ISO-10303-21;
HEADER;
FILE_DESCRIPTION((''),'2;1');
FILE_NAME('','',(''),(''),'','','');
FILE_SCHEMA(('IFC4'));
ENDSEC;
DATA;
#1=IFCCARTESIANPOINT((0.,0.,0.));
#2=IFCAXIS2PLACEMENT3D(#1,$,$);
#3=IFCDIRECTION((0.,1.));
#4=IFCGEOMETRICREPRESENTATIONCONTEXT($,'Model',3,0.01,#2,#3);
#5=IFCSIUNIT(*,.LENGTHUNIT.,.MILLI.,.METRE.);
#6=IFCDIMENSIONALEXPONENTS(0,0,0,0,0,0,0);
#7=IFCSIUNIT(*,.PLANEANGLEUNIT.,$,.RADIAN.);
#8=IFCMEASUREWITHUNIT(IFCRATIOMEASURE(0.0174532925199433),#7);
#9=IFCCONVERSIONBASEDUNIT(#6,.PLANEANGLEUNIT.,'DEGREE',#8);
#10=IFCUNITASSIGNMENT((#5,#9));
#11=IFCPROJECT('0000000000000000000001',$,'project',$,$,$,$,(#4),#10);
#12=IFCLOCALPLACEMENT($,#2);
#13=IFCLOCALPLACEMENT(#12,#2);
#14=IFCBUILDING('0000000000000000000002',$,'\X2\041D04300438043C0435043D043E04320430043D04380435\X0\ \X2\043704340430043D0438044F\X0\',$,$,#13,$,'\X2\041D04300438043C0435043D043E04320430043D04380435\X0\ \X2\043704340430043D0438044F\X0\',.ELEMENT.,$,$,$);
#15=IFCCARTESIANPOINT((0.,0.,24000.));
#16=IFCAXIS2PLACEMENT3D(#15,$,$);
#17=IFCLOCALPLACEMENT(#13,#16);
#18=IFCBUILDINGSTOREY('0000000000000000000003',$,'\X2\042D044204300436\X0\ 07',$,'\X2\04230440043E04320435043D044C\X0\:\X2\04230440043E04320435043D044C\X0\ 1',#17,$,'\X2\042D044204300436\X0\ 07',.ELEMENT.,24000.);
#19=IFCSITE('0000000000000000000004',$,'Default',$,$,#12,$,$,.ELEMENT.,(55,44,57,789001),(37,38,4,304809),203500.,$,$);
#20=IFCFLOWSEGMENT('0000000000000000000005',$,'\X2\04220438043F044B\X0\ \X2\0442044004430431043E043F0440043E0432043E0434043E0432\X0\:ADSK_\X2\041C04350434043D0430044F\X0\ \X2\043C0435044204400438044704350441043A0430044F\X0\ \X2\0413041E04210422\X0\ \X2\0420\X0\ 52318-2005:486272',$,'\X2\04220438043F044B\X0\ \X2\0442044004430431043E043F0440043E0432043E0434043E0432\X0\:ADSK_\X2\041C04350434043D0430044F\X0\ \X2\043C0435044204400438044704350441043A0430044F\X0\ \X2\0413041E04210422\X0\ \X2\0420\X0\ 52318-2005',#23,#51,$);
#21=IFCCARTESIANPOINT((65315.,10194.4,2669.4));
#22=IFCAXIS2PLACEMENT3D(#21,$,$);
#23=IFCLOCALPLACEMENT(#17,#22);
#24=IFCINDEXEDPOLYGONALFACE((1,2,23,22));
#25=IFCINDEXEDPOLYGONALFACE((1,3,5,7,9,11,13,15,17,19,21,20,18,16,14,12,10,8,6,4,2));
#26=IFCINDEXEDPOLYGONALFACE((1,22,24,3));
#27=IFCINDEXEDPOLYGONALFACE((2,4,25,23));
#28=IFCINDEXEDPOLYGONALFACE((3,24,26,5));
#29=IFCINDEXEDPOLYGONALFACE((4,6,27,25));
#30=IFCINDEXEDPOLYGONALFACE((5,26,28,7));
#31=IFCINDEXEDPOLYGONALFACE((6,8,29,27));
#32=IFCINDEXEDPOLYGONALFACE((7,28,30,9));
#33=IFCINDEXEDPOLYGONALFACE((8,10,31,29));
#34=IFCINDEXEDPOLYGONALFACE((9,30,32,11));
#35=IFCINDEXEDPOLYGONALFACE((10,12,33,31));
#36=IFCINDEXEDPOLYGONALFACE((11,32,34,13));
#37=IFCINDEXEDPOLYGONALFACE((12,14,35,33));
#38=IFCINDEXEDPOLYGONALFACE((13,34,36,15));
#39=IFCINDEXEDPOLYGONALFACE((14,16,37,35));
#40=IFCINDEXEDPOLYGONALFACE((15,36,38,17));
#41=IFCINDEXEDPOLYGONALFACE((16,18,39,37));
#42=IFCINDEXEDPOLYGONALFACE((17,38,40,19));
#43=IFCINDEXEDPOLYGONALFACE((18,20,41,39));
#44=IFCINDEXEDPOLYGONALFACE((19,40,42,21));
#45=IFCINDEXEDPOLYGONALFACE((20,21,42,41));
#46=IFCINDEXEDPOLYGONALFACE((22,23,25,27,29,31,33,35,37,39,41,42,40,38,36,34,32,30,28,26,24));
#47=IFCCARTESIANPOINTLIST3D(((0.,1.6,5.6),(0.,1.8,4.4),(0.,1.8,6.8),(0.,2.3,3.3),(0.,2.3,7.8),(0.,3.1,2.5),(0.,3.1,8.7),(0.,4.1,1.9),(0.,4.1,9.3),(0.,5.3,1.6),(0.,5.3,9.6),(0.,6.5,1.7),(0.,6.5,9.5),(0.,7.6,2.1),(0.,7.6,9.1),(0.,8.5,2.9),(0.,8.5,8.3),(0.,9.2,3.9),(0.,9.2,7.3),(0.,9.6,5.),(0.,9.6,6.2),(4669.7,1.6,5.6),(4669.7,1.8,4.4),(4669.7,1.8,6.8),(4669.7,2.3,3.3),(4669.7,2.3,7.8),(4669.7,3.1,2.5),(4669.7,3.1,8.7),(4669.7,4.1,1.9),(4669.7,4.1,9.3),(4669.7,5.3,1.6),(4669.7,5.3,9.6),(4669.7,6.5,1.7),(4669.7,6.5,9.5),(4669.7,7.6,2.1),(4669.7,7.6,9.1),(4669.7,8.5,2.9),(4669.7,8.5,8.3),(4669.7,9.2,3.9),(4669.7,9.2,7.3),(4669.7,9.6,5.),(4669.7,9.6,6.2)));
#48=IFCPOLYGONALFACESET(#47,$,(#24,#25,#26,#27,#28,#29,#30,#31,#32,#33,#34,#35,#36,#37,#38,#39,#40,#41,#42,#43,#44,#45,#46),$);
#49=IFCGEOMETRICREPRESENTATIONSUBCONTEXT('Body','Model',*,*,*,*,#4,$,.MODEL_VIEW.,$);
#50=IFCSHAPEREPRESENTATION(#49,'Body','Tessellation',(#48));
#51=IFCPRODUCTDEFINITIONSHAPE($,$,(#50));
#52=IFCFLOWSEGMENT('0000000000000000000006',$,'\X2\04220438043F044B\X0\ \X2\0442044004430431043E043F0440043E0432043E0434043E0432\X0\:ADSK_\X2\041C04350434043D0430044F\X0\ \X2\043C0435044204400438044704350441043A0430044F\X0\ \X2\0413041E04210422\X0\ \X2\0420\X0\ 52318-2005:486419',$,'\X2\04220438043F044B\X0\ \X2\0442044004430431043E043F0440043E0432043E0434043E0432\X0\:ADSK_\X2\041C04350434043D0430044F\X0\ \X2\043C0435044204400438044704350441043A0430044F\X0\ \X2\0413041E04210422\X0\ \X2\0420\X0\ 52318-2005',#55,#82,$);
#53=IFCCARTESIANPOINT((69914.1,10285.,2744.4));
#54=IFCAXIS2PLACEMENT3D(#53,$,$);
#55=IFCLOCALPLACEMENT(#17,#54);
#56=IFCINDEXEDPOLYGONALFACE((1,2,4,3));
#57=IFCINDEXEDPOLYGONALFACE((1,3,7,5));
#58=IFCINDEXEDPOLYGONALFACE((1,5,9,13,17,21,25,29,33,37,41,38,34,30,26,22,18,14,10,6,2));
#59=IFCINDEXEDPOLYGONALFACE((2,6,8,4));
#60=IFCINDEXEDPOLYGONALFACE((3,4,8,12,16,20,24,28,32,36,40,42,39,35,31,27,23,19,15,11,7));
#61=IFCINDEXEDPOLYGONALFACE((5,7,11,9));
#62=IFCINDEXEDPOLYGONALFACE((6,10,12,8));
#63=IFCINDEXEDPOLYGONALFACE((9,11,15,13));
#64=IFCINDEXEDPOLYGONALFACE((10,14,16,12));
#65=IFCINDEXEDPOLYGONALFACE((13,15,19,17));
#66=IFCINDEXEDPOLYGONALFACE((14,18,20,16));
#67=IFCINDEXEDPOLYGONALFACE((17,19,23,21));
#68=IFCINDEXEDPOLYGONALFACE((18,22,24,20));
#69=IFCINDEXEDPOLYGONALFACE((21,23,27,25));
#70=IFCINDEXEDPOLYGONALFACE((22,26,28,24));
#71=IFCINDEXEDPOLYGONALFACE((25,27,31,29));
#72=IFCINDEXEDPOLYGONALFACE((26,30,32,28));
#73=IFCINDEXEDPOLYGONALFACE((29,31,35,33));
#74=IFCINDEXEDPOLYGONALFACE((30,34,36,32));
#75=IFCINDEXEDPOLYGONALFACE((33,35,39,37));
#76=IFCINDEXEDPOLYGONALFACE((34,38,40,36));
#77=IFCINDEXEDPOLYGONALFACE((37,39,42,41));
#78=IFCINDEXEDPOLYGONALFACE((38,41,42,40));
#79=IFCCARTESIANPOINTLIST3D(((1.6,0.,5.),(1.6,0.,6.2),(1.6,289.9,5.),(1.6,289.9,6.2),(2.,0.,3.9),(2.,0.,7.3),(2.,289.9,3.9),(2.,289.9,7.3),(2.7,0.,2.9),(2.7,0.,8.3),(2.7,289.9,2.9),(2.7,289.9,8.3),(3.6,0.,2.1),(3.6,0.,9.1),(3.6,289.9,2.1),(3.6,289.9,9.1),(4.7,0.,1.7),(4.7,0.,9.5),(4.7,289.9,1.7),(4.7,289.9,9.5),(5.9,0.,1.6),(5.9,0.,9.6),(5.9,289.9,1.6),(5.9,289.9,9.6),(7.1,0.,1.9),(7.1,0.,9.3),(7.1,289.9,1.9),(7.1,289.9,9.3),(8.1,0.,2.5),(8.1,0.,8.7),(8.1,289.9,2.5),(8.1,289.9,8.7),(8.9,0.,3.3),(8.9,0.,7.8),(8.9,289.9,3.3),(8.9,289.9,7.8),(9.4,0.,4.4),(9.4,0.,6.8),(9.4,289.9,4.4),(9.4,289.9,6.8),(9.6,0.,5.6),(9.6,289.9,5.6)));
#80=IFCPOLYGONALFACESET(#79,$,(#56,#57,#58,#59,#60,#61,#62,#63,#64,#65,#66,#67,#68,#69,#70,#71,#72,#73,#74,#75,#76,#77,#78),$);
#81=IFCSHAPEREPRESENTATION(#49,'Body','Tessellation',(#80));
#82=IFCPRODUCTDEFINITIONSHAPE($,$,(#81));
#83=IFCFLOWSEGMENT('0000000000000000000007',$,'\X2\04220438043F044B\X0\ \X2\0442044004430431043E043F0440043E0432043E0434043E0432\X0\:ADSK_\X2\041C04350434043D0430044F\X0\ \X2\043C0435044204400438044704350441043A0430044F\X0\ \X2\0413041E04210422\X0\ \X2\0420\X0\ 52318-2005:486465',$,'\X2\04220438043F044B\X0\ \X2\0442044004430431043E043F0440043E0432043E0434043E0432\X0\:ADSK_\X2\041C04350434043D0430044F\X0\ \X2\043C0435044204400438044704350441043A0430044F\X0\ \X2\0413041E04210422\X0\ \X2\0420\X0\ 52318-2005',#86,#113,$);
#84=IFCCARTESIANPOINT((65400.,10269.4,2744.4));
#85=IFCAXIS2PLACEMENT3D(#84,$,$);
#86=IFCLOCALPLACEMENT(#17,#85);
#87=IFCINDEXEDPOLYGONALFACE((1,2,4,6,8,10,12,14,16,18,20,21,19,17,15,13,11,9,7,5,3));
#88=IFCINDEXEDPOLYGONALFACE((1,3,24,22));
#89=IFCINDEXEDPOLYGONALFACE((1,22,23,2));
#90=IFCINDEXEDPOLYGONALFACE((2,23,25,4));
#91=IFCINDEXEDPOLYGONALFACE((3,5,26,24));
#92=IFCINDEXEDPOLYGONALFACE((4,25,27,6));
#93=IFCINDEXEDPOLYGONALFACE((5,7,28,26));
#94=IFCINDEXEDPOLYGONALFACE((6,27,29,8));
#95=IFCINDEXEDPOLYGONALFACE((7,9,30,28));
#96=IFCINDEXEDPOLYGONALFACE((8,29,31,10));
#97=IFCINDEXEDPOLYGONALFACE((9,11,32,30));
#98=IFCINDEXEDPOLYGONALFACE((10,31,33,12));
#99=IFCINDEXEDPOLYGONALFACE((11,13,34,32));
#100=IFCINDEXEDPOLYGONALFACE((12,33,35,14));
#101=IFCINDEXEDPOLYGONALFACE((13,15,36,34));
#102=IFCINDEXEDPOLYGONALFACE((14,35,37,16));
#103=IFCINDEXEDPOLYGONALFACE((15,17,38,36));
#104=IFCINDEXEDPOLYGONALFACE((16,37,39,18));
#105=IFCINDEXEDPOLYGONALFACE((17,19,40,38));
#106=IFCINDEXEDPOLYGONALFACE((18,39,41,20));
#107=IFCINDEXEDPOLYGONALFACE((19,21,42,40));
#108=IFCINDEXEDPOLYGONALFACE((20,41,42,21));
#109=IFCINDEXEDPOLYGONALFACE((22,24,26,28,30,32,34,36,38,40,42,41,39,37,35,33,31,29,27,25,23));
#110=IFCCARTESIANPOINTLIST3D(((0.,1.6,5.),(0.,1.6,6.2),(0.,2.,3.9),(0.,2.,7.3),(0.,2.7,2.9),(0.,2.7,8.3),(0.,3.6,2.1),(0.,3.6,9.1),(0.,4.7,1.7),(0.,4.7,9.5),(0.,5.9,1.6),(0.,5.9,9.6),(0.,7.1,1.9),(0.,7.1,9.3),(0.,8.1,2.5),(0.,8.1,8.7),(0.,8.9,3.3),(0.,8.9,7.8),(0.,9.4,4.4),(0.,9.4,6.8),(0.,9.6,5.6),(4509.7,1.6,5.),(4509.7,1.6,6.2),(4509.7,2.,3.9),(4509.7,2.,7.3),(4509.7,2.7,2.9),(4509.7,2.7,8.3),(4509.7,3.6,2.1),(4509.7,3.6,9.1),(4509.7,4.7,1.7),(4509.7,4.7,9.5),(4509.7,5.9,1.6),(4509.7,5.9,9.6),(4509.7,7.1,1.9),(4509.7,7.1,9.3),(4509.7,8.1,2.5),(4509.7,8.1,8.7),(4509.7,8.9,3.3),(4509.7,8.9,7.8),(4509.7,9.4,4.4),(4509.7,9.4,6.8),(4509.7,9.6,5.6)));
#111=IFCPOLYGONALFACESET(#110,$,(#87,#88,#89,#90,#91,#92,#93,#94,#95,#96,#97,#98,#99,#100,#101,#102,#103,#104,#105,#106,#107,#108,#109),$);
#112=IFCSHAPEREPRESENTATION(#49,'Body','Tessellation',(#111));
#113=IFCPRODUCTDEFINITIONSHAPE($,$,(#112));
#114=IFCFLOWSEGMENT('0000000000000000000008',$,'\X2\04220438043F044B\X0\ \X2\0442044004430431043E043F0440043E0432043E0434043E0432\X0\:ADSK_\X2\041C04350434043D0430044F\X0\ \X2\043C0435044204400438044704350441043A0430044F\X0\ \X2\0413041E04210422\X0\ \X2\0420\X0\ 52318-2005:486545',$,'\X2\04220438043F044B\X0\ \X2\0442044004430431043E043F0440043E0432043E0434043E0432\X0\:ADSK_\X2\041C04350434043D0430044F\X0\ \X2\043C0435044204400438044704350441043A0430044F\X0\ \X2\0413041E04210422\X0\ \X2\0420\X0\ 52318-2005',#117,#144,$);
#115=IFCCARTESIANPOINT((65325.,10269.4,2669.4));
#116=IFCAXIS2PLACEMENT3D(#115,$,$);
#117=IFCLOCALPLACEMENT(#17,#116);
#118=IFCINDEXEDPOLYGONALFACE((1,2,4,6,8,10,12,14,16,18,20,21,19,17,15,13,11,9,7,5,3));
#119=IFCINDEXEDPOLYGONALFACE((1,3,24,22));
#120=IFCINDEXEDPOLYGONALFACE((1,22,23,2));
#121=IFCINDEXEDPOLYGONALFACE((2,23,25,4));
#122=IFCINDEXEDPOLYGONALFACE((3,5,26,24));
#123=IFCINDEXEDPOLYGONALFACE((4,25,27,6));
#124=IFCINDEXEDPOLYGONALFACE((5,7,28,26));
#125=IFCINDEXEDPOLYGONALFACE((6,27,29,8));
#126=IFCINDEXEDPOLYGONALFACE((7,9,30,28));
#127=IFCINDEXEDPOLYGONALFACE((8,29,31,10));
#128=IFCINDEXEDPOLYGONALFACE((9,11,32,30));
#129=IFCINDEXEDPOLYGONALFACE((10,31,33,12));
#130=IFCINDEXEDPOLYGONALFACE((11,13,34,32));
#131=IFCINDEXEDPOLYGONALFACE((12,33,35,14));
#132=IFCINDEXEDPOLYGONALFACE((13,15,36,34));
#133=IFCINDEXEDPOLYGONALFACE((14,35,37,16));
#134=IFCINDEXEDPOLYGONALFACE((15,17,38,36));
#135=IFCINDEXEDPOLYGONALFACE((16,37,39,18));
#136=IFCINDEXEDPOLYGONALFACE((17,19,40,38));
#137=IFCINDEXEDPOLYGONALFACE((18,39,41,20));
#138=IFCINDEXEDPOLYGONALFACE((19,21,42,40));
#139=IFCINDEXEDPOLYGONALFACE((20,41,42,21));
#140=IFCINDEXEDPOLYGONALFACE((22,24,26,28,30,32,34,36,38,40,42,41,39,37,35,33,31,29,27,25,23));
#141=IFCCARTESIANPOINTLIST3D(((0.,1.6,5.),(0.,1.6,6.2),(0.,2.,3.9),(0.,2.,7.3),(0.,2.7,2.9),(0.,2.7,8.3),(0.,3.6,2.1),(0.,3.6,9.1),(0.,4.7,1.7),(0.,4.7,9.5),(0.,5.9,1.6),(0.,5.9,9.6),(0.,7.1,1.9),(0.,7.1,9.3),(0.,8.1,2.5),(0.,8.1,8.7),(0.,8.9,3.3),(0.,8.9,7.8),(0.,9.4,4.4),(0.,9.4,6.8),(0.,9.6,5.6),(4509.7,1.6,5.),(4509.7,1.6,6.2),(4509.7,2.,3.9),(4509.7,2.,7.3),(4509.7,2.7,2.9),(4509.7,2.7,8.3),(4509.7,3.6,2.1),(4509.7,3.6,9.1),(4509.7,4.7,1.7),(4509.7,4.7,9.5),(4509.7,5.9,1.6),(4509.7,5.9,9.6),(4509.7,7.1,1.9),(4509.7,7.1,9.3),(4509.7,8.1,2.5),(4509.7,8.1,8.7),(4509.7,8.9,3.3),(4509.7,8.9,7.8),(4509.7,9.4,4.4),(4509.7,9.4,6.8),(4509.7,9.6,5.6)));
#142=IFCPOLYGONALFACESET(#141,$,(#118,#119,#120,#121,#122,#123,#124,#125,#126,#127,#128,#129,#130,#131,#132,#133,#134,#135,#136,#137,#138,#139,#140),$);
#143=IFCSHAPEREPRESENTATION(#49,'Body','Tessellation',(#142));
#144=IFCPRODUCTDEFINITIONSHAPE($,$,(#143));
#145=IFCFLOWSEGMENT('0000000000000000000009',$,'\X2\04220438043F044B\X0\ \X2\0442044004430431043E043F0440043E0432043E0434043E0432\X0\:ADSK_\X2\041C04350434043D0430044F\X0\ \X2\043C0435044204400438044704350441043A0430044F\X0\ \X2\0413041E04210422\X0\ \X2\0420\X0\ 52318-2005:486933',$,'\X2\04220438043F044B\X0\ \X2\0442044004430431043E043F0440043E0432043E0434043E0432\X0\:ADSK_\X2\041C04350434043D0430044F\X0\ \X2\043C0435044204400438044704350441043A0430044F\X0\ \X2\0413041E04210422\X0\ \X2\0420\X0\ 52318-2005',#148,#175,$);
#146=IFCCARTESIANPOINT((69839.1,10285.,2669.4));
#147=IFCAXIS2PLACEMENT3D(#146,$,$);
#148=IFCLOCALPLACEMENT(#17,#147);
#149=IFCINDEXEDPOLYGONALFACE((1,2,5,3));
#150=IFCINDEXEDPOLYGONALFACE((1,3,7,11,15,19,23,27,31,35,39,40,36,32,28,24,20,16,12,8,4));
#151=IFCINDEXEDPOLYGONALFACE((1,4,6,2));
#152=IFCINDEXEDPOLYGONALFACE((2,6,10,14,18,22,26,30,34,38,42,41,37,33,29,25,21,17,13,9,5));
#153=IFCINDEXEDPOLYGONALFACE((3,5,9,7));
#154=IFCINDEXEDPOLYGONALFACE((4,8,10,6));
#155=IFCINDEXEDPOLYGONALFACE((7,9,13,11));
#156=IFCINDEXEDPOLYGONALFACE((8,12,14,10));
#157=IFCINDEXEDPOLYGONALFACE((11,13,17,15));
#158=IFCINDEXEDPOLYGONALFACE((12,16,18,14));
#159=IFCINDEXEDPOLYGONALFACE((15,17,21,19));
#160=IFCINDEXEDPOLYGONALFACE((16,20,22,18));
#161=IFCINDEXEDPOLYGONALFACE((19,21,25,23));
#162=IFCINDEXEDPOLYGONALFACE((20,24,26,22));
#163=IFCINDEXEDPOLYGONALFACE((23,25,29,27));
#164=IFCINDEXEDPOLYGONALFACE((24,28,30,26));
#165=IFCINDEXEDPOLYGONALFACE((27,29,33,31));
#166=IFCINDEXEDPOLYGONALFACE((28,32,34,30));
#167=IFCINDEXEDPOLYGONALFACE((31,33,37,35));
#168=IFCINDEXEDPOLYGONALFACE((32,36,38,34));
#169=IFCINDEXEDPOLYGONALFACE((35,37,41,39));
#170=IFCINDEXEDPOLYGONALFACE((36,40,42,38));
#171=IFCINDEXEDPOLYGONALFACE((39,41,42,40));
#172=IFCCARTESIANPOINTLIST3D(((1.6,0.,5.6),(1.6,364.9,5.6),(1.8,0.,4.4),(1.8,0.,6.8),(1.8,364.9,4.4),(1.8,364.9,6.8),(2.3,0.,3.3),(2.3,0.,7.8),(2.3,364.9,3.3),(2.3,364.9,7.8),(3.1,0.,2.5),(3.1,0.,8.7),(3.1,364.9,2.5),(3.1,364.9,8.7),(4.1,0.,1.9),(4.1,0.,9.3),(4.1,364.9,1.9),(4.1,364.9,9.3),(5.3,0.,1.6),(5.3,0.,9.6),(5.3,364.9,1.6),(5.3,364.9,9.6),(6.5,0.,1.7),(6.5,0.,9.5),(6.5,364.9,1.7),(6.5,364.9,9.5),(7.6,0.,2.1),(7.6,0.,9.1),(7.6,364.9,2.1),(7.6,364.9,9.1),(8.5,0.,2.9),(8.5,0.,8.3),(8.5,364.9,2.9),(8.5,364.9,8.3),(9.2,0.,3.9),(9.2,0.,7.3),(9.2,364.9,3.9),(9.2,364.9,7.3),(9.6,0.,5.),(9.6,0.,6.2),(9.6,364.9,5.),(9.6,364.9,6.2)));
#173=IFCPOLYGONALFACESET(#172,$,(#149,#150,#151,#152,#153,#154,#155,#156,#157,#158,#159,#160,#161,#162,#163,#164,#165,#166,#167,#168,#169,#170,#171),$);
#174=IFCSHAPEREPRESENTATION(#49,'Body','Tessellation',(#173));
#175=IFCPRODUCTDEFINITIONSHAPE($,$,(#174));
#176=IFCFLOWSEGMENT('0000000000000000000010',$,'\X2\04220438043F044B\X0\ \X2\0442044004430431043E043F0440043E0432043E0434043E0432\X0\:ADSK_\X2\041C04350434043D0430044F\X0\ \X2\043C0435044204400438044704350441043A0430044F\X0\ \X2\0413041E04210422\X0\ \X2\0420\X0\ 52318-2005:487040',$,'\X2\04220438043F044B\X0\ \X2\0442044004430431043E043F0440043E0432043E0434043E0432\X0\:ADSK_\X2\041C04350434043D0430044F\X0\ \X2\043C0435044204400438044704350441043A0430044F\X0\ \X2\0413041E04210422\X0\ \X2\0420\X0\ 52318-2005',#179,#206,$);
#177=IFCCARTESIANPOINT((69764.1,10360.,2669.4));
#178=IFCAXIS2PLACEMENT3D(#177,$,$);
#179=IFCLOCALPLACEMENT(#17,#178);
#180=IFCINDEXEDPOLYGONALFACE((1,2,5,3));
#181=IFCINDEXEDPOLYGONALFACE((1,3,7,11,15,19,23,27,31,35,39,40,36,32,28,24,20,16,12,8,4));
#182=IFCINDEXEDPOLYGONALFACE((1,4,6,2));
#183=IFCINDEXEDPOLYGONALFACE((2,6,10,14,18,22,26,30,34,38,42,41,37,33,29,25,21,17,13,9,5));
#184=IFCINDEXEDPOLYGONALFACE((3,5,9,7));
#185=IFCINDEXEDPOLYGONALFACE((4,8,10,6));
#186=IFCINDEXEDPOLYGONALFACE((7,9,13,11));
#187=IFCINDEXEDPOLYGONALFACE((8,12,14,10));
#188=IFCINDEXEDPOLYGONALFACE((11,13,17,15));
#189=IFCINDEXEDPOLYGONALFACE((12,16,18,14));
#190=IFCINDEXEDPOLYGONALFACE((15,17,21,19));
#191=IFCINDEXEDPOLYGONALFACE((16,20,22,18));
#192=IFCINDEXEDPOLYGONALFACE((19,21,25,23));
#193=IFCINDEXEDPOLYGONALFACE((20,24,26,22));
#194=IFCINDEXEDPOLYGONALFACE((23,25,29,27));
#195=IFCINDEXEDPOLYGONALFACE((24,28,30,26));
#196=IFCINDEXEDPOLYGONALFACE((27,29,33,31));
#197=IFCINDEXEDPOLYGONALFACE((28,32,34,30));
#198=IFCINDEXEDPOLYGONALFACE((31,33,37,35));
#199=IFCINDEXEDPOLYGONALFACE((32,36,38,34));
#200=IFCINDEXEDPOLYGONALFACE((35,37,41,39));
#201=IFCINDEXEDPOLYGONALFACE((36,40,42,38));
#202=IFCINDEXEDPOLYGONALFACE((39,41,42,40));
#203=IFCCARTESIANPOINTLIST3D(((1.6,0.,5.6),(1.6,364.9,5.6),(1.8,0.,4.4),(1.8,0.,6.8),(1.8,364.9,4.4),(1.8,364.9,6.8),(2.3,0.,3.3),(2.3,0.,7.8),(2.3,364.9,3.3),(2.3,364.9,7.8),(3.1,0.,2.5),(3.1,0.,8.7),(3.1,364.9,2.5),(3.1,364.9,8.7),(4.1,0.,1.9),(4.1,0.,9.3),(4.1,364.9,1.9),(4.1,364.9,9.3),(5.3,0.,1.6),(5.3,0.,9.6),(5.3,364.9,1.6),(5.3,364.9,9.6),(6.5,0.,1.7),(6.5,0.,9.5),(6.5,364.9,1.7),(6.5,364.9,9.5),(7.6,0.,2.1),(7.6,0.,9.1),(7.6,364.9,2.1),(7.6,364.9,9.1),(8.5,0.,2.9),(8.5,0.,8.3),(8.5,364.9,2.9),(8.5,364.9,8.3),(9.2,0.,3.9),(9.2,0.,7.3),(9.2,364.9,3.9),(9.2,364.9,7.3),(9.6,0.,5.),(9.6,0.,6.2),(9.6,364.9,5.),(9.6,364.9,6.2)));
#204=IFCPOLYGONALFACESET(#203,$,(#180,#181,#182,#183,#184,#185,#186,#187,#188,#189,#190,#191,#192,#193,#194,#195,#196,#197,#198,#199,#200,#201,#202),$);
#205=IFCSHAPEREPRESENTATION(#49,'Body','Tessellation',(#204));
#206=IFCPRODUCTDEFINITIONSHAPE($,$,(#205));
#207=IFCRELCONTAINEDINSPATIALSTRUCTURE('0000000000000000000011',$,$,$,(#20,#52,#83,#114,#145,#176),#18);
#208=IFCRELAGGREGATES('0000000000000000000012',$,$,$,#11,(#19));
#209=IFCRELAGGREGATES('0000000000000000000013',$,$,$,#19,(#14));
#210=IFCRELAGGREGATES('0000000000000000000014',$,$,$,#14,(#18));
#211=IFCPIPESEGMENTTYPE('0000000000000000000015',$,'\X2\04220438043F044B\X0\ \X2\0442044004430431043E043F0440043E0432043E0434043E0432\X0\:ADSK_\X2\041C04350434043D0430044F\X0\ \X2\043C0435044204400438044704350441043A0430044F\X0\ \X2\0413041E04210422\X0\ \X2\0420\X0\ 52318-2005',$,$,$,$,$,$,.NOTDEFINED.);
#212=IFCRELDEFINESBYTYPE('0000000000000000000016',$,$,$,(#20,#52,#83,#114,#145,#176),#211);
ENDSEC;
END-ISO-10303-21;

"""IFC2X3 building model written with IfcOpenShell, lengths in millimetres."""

from ifc_helpers import new_model, entity, si_unit, converted_unit, direction, frame, frame_2d, origin, origin_2d_with_axis, place, context, subcontext, project, spatial, circle, extrude, type_object, element, save


model = new_model("IFC2X3")

# Units and contexts
model_context = context("Model", 3, precision=0.01, world=origin(), true_north=direction((0.0, 1.0)))
body_context = subcontext(model_context, "Body", "Model", "MODEL_VIEW")
ifc_project = project(units=[si_unit("LENGTHUNIT", "METRE", prefix="MILLI"), converted_unit("PLANEANGLEUNIT", "DEGREE", entity("IfcRatioMeasure", 0.0174532925199433), si_unit("PLANEANGLEUNIT", "RADIAN"), dimensions=[0, 0, 0, 0, 0, 0, 0])], contexts=[model_context])

# Site, building, storey
site_placement = place(None, frame((0.0, 0.0, 0.0)))
site = spatial("IfcSite", under=ifc_project, at=site_placement, Name="Default", CompositionType="ELEMENT", RefLatitude=(55, 44, 57, 789001), RefLongitude=(37, 38, 4, 304809), RefElevation=203500.0)
building_placement = place(site_placement, origin())
building = spatial("IfcBuilding", under=site, at=building_placement, Name="Наименование здания", LongName="Наименование здания", CompositionType="ELEMENT")
storey_placement = place(building_placement, frame((0.0, 0.0, 24000.0)))
storey = spatial("IfcBuildingStorey", under=building, at=storey_placement, Name="Этаж 07", ObjectType="Уровень:Уровень 1", LongName="Этаж 07", CompositionType="ELEMENT", Elevation=24000.0)

# Flow segments
pipe_segment_type = type_object("IfcPipeSegmentType", Name="Типы трубопроводов:ADSK_Медная метрическая ГОСТ Р 52318-2005", PredefinedType="NOTDEFINED")
flow_segment_1_placement = place(storey_placement, frame((65315.0, 10194.4, 2669.4)))
element("IfcFlowSegment", 1, at=flow_segment_1_placement, inside=storey, type_object=pipe_segment_type, Name="Типы трубопроводов:ADSK_Медная метрическая ГОСТ Р 52318-2005:486272", ObjectType="Типы трубопроводов:ADSK_Медная метрическая ГОСТ Р 52318-2005", context=body_context, shape_type="SweptSolid", body=[
    extrude(circle(Radius=4.0, at=origin_2d_with_axis()), frame((0.0, 5.6, 5.6), z_axis=(1.0, 0.0, 0.0), x_axis=(0.0, -1.0, 0.0)), (0.0, 0.0, 1.0), 4669.7),
])
flow_segment_2_placement = place(storey_placement, frame((69914.1, 10285.0, 2744.4)))
element("IfcFlowSegment", 2, at=flow_segment_2_placement, inside=storey, type_object=pipe_segment_type, Name="Типы трубопроводов:ADSK_Медная метрическая ГОСТ Р 52318-2005:486419", ObjectType="Типы трубопроводов:ADSK_Медная метрическая ГОСТ Р 52318-2005", context=body_context, shape_type="SweptSolid", body=[
    extrude(circle(Radius=4.0, at=frame_2d((0.0, 0.0), x_axis=(1.0, 0.0))), frame((5.6, 0.0, 5.6), z_axis=(0.0, 1.0, 0.0), x_axis=(1.0, 0.0, 0.0)), (0.0, 0.0, 1.0), 289.9),
])
flow_segment_3_placement = place(storey_placement, frame((65400.0, 10269.4, 2744.4)))
element("IfcFlowSegment", 3, at=flow_segment_3_placement, inside=storey, type_object=pipe_segment_type, Name="Типы трубопроводов:ADSK_Медная метрическая ГОСТ Р 52318-2005:486465", ObjectType="Типы трубопроводов:ADSK_Медная метрическая ГОСТ Р 52318-2005", context=body_context, shape_type="SweptSolid", body=[
    extrude(circle(Radius=4.0, at=origin_2d_with_axis()), frame((0.0, 5.6, 5.6), z_axis=(1.0, 0.0, 0.0), x_axis=(0.0, 1.0, 0.0)), (0.0, 0.0, 1.0), 4509.7),
])
flow_segment_4_placement = place(storey_placement, frame((65325.0, 10269.4, 2669.4)))
element("IfcFlowSegment", 4, at=flow_segment_4_placement, inside=storey, type_object=pipe_segment_type, Name="Типы трубопроводов:ADSK_Медная метрическая ГОСТ Р 52318-2005:486545", ObjectType="Типы трубопроводов:ADSK_Медная метрическая ГОСТ Р 52318-2005", context=body_context, shape_type="SweptSolid", body=[
    extrude(circle(Radius=4.0, at=frame_2d((0.0, 0.0), x_axis=(1.0, 0.0))), frame((0.0, 5.6, 5.6), z_axis=(1.0, 0.0, 0.0), x_axis=(0.0, 1.0, 0.0)), (0.0, 0.0, 1.0), 4509.7),
])
flow_segment_5_placement = place(storey_placement, frame((69839.1, 10285.0, 2669.4)))
element("IfcFlowSegment", 5, at=flow_segment_5_placement, inside=storey, type_object=pipe_segment_type, Name="Типы трубопроводов:ADSK_Медная метрическая ГОСТ Р 52318-2005:486933", ObjectType="Типы трубопроводов:ADSK_Медная метрическая ГОСТ Р 52318-2005", context=body_context, shape_type="SweptSolid", body=[
    extrude(circle(Radius=4.0, at=origin_2d_with_axis()), frame((5.6, 0.0, 5.6), z_axis=(0.0, 1.0, 0.0), x_axis=(-1.0, 0.0, 0.0)), (0.0, 0.0, 1.0), 364.9),
])
flow_segment_6_placement = place(storey_placement, frame((69764.1, 10360.0, 2669.4)))
element("IfcFlowSegment", 6, at=flow_segment_6_placement, inside=storey, type_object=pipe_segment_type, Name="Типы трубопроводов:ADSK_Медная метрическая ГОСТ Р 52318-2005:487040", ObjectType="Типы трубопроводов:ADSK_Медная метрическая ГОСТ Р 52318-2005", context=body_context, shape_type="SweptSolid", body=[
    extrude(circle(Radius=4.0, at=origin_2d_with_axis()), frame((5.6, 0.0, 5.6), z_axis=(0.0, 1.0, 0.0), x_axis=(-1.0, 0.0, 0.0)), (0.0, 0.0, 1.0), 364.9),
])

save(model, "model.ifc")
